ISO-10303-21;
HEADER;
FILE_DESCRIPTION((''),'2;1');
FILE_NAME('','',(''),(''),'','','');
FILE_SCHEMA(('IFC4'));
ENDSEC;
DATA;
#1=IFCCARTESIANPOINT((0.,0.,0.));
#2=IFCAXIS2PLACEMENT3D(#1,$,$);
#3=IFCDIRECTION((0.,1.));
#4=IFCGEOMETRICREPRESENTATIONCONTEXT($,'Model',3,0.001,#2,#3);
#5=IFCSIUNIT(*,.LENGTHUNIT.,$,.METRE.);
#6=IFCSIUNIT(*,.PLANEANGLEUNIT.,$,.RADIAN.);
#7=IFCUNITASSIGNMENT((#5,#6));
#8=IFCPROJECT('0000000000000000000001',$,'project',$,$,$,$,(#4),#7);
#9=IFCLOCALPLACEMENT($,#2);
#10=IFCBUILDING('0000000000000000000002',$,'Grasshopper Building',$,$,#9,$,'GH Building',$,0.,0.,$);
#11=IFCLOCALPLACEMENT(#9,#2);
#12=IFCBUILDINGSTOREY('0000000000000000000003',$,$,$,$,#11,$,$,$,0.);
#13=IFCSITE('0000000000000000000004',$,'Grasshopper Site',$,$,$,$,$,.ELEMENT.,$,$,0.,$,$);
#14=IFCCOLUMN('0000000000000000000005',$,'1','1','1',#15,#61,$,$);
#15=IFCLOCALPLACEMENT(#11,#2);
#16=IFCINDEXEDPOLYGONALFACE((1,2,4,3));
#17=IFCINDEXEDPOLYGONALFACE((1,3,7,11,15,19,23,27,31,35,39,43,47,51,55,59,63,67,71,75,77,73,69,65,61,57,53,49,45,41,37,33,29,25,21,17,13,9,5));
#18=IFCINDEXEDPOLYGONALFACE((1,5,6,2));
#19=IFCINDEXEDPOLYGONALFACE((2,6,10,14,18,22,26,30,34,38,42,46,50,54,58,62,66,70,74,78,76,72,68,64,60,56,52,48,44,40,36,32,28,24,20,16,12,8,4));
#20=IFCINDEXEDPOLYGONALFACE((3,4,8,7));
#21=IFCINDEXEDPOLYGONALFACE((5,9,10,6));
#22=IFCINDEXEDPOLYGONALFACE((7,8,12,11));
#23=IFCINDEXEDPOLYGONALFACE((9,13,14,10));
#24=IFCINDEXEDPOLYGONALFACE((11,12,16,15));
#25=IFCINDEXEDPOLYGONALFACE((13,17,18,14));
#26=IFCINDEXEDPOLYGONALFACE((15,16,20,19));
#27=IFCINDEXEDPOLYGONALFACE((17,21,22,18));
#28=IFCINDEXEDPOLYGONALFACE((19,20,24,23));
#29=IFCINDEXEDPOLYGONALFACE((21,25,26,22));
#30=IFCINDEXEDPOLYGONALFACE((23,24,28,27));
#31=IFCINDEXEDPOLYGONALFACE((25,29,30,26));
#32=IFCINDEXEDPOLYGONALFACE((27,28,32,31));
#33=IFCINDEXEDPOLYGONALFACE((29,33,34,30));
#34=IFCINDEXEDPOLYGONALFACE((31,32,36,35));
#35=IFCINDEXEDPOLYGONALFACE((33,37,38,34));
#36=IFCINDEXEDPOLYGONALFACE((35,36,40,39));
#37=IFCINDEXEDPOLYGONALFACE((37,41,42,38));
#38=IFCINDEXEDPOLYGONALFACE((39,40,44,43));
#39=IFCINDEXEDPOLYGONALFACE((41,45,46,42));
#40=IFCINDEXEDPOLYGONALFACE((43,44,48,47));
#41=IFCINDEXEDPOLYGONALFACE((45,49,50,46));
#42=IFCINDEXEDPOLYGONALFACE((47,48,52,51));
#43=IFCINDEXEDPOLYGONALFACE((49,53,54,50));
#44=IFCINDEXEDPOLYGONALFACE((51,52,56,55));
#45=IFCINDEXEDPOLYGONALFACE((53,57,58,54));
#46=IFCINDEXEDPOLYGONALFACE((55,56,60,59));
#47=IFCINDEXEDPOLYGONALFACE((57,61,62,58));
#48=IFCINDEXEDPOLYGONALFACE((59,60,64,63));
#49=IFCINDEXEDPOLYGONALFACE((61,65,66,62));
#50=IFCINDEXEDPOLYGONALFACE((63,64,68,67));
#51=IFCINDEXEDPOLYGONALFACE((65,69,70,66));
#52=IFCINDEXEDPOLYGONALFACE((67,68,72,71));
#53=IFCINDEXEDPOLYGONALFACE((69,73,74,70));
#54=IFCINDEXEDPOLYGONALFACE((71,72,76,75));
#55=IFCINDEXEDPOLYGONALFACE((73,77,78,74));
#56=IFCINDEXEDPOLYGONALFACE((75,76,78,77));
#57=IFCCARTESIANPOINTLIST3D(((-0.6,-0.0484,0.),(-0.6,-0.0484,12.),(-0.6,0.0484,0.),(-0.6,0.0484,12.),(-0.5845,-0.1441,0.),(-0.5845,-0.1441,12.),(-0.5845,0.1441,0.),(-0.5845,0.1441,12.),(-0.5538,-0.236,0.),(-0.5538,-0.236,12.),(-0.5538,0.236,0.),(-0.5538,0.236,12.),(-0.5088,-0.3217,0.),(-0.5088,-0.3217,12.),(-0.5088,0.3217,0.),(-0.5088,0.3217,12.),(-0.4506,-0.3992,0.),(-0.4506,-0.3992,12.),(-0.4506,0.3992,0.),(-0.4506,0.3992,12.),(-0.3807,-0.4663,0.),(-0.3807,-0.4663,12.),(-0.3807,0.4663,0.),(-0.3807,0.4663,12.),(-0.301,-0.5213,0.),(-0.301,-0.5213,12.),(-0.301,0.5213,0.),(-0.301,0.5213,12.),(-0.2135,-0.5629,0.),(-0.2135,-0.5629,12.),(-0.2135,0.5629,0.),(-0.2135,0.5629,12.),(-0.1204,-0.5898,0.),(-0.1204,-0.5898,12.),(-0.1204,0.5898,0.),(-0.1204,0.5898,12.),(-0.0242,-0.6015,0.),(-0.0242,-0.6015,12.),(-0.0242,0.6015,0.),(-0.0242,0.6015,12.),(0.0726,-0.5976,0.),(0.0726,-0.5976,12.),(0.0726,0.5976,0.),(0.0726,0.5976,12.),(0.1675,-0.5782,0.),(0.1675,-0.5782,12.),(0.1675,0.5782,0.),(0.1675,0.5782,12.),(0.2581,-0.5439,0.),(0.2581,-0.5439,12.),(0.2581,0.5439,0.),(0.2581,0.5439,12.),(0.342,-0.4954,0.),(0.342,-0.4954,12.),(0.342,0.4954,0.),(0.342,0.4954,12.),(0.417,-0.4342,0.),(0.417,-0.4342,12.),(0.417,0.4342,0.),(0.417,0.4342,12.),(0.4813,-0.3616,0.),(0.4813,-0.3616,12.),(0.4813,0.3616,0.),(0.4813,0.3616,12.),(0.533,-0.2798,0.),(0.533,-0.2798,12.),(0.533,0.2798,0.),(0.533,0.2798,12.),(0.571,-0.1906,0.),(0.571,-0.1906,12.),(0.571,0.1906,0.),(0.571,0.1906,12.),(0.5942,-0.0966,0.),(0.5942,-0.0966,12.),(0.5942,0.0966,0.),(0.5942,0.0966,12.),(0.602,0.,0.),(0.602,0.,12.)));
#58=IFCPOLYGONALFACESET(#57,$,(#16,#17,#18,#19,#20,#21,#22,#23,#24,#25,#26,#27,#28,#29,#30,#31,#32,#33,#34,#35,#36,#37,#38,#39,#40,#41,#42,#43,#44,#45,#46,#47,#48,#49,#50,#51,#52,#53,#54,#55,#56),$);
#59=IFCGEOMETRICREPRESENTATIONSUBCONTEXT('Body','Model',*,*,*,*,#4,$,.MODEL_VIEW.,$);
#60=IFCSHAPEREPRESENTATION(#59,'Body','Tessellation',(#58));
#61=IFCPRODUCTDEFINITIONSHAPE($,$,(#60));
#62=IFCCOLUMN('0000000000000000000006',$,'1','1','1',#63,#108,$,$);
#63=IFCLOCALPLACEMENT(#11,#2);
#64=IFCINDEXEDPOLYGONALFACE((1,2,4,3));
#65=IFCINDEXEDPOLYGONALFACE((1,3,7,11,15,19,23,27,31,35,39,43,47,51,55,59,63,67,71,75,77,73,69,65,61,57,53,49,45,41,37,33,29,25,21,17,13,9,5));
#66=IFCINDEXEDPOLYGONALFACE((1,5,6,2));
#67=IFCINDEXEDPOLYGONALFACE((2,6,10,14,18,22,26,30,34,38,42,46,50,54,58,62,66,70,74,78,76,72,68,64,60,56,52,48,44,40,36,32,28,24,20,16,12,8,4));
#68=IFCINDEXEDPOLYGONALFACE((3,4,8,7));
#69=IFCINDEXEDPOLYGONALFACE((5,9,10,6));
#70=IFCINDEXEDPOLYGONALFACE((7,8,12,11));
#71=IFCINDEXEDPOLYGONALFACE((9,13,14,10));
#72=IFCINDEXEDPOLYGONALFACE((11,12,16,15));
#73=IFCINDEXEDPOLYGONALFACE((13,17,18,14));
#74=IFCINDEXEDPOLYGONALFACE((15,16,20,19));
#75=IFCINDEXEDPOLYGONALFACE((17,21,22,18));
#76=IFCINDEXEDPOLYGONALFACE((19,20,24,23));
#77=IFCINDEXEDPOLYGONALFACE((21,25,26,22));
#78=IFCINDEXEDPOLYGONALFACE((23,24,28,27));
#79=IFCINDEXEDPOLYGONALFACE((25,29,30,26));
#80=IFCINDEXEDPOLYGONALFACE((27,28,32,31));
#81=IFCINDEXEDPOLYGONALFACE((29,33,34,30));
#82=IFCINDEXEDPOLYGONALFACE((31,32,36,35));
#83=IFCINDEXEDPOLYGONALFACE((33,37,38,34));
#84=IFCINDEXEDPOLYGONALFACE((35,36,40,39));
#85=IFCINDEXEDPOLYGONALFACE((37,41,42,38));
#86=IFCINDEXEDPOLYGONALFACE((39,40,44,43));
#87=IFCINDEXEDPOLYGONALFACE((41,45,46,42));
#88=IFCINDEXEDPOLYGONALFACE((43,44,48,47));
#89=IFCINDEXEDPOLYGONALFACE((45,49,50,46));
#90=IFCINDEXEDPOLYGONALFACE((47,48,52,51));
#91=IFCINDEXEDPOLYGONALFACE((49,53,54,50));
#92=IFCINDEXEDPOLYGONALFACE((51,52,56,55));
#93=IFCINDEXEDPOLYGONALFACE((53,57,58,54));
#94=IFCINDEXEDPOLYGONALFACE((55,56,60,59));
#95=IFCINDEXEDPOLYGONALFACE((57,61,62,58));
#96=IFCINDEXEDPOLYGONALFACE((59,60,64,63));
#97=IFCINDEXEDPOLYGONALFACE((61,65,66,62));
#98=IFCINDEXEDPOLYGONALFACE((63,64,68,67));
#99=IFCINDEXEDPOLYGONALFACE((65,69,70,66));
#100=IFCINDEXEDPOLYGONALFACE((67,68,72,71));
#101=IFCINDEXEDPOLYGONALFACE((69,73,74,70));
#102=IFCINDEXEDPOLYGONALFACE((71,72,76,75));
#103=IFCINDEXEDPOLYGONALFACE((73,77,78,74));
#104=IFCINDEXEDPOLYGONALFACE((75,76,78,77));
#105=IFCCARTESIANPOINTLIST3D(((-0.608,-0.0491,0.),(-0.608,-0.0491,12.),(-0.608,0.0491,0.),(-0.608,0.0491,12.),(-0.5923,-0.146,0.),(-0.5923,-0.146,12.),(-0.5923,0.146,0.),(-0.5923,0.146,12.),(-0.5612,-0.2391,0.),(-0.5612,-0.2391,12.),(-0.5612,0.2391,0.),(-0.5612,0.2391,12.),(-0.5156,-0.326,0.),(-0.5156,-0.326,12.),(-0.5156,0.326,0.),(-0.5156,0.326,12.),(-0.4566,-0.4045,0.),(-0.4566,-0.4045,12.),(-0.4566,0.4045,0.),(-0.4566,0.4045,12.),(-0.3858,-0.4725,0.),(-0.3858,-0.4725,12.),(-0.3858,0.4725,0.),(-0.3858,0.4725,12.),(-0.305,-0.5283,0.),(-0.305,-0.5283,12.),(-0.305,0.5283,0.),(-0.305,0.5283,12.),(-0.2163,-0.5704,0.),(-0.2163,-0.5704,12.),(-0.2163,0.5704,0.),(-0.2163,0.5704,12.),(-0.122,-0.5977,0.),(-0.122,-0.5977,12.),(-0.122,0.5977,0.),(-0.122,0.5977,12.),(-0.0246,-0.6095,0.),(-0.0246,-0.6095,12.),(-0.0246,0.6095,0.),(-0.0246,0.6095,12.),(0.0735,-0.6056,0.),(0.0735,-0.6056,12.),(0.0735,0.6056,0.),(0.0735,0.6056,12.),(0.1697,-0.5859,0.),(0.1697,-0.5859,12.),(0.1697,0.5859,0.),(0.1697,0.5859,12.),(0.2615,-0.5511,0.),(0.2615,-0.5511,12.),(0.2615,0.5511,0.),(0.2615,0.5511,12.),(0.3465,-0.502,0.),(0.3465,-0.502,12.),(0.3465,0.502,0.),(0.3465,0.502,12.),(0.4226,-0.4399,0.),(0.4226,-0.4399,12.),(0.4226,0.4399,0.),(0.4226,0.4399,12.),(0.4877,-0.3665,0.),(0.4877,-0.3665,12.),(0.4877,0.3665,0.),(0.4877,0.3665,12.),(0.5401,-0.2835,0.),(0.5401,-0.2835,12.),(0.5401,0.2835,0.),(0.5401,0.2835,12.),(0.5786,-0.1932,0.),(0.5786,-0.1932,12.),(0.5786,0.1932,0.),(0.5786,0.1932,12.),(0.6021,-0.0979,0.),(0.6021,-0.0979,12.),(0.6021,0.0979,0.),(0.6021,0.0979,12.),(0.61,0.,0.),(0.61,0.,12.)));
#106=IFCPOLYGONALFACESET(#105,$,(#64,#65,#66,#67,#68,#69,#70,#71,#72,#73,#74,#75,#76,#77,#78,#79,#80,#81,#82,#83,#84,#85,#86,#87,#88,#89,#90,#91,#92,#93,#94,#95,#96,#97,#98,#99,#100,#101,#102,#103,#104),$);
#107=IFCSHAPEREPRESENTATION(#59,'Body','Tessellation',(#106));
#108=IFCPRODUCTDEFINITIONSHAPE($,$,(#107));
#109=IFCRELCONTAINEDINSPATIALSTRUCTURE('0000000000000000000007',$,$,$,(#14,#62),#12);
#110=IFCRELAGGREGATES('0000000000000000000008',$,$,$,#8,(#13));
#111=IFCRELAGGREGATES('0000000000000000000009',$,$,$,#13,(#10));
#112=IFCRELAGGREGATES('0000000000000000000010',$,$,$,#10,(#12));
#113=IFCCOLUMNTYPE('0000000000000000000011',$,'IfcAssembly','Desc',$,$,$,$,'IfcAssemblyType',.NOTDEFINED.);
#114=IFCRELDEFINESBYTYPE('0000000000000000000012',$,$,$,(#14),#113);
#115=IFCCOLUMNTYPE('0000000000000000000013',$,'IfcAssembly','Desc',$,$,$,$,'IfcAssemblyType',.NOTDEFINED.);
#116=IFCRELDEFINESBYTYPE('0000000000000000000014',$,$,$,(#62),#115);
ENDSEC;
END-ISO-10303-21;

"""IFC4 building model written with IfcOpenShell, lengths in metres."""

from ifc_helpers import new_model, si_unit, direction, origin, place, context, subcontext, project, spatial, circle, extrude, source, transform, mapped, type_object, type_shapes, element, save


model = new_model("IFC4")

# Units and contexts
model_context = context("Model", 3, precision=0.001, world=origin(), true_north=direction((0.0, 1.0)))
body_context = subcontext(model_context, "Body", "Model", "MODEL_VIEW")
ifc_project = project(units=[si_unit("LENGTHUNIT", "METRE"), si_unit("PLANEANGLEUNIT", "RADIAN")], contexts=[model_context])

# Site, building, storey
site = spatial("IfcSite", under=ifc_project, Name="Grasshopper Site", CompositionType="ELEMENT", RefElevation=0.0)
building_placement = place(None, origin())
building = spatial("IfcBuilding", under=site, at=building_placement, Name="Grasshopper Building", LongName="GH Building", ElevationOfRefHeight=0.0, ElevationOfTerrain=0.0)
storey_placement = place(building_placement, origin())
storey = spatial("IfcBuildingStorey", under=building, at=storey_placement, Elevation=0.0)

# Columns
column_type_1 = type_object("IfcColumnType", Name="IfcAssembly", Description="Desc", ElementType="IfcAssemblyType", PredefinedType="NOTDEFINED")
shared_shape_1 = source(origin(), body_context, "Body", "SweptSolid", [extrude(circle(Radius=0.602), None, (0.0, 0.0, 1.0), 12.0)])
type_shapes(column_type_1, [shared_shape_1])
column_1_placement = place(storey_placement, origin())
element("IfcColumn", 1, at=column_1_placement, inside=storey, type_object=column_type_1, Name="1", Description="1", ObjectType="1", context=body_context, shape_type="MappedRepresentation", body=[
    mapped(shared_shape_1, transform((0.0, 0.0, 0.0), scale=1.0)),
])
column_type_2 = type_object("IfcColumnType", Name="IfcAssembly", Description="Desc", ElementType="IfcAssemblyType", PredefinedType="NOTDEFINED")
shared_shape_2 = source(origin(), body_context, "Body", "SweptSolid", [extrude(circle(Radius=0.61), None, (0.0, 0.0, 1.0), 12.0)])
type_shapes(column_type_2, [shared_shape_2])
column_2_placement = place(storey_placement, origin())
element("IfcColumn", 2, at=column_2_placement, inside=storey, type_object=column_type_2, Name="1", Description="1", ObjectType="1", context=body_context, shape_type="MappedRepresentation", body=[
    mapped(shared_shape_2, transform((0.0, 0.0, 0.0), scale=1.0)),
])

save(model, "model.ifc")
